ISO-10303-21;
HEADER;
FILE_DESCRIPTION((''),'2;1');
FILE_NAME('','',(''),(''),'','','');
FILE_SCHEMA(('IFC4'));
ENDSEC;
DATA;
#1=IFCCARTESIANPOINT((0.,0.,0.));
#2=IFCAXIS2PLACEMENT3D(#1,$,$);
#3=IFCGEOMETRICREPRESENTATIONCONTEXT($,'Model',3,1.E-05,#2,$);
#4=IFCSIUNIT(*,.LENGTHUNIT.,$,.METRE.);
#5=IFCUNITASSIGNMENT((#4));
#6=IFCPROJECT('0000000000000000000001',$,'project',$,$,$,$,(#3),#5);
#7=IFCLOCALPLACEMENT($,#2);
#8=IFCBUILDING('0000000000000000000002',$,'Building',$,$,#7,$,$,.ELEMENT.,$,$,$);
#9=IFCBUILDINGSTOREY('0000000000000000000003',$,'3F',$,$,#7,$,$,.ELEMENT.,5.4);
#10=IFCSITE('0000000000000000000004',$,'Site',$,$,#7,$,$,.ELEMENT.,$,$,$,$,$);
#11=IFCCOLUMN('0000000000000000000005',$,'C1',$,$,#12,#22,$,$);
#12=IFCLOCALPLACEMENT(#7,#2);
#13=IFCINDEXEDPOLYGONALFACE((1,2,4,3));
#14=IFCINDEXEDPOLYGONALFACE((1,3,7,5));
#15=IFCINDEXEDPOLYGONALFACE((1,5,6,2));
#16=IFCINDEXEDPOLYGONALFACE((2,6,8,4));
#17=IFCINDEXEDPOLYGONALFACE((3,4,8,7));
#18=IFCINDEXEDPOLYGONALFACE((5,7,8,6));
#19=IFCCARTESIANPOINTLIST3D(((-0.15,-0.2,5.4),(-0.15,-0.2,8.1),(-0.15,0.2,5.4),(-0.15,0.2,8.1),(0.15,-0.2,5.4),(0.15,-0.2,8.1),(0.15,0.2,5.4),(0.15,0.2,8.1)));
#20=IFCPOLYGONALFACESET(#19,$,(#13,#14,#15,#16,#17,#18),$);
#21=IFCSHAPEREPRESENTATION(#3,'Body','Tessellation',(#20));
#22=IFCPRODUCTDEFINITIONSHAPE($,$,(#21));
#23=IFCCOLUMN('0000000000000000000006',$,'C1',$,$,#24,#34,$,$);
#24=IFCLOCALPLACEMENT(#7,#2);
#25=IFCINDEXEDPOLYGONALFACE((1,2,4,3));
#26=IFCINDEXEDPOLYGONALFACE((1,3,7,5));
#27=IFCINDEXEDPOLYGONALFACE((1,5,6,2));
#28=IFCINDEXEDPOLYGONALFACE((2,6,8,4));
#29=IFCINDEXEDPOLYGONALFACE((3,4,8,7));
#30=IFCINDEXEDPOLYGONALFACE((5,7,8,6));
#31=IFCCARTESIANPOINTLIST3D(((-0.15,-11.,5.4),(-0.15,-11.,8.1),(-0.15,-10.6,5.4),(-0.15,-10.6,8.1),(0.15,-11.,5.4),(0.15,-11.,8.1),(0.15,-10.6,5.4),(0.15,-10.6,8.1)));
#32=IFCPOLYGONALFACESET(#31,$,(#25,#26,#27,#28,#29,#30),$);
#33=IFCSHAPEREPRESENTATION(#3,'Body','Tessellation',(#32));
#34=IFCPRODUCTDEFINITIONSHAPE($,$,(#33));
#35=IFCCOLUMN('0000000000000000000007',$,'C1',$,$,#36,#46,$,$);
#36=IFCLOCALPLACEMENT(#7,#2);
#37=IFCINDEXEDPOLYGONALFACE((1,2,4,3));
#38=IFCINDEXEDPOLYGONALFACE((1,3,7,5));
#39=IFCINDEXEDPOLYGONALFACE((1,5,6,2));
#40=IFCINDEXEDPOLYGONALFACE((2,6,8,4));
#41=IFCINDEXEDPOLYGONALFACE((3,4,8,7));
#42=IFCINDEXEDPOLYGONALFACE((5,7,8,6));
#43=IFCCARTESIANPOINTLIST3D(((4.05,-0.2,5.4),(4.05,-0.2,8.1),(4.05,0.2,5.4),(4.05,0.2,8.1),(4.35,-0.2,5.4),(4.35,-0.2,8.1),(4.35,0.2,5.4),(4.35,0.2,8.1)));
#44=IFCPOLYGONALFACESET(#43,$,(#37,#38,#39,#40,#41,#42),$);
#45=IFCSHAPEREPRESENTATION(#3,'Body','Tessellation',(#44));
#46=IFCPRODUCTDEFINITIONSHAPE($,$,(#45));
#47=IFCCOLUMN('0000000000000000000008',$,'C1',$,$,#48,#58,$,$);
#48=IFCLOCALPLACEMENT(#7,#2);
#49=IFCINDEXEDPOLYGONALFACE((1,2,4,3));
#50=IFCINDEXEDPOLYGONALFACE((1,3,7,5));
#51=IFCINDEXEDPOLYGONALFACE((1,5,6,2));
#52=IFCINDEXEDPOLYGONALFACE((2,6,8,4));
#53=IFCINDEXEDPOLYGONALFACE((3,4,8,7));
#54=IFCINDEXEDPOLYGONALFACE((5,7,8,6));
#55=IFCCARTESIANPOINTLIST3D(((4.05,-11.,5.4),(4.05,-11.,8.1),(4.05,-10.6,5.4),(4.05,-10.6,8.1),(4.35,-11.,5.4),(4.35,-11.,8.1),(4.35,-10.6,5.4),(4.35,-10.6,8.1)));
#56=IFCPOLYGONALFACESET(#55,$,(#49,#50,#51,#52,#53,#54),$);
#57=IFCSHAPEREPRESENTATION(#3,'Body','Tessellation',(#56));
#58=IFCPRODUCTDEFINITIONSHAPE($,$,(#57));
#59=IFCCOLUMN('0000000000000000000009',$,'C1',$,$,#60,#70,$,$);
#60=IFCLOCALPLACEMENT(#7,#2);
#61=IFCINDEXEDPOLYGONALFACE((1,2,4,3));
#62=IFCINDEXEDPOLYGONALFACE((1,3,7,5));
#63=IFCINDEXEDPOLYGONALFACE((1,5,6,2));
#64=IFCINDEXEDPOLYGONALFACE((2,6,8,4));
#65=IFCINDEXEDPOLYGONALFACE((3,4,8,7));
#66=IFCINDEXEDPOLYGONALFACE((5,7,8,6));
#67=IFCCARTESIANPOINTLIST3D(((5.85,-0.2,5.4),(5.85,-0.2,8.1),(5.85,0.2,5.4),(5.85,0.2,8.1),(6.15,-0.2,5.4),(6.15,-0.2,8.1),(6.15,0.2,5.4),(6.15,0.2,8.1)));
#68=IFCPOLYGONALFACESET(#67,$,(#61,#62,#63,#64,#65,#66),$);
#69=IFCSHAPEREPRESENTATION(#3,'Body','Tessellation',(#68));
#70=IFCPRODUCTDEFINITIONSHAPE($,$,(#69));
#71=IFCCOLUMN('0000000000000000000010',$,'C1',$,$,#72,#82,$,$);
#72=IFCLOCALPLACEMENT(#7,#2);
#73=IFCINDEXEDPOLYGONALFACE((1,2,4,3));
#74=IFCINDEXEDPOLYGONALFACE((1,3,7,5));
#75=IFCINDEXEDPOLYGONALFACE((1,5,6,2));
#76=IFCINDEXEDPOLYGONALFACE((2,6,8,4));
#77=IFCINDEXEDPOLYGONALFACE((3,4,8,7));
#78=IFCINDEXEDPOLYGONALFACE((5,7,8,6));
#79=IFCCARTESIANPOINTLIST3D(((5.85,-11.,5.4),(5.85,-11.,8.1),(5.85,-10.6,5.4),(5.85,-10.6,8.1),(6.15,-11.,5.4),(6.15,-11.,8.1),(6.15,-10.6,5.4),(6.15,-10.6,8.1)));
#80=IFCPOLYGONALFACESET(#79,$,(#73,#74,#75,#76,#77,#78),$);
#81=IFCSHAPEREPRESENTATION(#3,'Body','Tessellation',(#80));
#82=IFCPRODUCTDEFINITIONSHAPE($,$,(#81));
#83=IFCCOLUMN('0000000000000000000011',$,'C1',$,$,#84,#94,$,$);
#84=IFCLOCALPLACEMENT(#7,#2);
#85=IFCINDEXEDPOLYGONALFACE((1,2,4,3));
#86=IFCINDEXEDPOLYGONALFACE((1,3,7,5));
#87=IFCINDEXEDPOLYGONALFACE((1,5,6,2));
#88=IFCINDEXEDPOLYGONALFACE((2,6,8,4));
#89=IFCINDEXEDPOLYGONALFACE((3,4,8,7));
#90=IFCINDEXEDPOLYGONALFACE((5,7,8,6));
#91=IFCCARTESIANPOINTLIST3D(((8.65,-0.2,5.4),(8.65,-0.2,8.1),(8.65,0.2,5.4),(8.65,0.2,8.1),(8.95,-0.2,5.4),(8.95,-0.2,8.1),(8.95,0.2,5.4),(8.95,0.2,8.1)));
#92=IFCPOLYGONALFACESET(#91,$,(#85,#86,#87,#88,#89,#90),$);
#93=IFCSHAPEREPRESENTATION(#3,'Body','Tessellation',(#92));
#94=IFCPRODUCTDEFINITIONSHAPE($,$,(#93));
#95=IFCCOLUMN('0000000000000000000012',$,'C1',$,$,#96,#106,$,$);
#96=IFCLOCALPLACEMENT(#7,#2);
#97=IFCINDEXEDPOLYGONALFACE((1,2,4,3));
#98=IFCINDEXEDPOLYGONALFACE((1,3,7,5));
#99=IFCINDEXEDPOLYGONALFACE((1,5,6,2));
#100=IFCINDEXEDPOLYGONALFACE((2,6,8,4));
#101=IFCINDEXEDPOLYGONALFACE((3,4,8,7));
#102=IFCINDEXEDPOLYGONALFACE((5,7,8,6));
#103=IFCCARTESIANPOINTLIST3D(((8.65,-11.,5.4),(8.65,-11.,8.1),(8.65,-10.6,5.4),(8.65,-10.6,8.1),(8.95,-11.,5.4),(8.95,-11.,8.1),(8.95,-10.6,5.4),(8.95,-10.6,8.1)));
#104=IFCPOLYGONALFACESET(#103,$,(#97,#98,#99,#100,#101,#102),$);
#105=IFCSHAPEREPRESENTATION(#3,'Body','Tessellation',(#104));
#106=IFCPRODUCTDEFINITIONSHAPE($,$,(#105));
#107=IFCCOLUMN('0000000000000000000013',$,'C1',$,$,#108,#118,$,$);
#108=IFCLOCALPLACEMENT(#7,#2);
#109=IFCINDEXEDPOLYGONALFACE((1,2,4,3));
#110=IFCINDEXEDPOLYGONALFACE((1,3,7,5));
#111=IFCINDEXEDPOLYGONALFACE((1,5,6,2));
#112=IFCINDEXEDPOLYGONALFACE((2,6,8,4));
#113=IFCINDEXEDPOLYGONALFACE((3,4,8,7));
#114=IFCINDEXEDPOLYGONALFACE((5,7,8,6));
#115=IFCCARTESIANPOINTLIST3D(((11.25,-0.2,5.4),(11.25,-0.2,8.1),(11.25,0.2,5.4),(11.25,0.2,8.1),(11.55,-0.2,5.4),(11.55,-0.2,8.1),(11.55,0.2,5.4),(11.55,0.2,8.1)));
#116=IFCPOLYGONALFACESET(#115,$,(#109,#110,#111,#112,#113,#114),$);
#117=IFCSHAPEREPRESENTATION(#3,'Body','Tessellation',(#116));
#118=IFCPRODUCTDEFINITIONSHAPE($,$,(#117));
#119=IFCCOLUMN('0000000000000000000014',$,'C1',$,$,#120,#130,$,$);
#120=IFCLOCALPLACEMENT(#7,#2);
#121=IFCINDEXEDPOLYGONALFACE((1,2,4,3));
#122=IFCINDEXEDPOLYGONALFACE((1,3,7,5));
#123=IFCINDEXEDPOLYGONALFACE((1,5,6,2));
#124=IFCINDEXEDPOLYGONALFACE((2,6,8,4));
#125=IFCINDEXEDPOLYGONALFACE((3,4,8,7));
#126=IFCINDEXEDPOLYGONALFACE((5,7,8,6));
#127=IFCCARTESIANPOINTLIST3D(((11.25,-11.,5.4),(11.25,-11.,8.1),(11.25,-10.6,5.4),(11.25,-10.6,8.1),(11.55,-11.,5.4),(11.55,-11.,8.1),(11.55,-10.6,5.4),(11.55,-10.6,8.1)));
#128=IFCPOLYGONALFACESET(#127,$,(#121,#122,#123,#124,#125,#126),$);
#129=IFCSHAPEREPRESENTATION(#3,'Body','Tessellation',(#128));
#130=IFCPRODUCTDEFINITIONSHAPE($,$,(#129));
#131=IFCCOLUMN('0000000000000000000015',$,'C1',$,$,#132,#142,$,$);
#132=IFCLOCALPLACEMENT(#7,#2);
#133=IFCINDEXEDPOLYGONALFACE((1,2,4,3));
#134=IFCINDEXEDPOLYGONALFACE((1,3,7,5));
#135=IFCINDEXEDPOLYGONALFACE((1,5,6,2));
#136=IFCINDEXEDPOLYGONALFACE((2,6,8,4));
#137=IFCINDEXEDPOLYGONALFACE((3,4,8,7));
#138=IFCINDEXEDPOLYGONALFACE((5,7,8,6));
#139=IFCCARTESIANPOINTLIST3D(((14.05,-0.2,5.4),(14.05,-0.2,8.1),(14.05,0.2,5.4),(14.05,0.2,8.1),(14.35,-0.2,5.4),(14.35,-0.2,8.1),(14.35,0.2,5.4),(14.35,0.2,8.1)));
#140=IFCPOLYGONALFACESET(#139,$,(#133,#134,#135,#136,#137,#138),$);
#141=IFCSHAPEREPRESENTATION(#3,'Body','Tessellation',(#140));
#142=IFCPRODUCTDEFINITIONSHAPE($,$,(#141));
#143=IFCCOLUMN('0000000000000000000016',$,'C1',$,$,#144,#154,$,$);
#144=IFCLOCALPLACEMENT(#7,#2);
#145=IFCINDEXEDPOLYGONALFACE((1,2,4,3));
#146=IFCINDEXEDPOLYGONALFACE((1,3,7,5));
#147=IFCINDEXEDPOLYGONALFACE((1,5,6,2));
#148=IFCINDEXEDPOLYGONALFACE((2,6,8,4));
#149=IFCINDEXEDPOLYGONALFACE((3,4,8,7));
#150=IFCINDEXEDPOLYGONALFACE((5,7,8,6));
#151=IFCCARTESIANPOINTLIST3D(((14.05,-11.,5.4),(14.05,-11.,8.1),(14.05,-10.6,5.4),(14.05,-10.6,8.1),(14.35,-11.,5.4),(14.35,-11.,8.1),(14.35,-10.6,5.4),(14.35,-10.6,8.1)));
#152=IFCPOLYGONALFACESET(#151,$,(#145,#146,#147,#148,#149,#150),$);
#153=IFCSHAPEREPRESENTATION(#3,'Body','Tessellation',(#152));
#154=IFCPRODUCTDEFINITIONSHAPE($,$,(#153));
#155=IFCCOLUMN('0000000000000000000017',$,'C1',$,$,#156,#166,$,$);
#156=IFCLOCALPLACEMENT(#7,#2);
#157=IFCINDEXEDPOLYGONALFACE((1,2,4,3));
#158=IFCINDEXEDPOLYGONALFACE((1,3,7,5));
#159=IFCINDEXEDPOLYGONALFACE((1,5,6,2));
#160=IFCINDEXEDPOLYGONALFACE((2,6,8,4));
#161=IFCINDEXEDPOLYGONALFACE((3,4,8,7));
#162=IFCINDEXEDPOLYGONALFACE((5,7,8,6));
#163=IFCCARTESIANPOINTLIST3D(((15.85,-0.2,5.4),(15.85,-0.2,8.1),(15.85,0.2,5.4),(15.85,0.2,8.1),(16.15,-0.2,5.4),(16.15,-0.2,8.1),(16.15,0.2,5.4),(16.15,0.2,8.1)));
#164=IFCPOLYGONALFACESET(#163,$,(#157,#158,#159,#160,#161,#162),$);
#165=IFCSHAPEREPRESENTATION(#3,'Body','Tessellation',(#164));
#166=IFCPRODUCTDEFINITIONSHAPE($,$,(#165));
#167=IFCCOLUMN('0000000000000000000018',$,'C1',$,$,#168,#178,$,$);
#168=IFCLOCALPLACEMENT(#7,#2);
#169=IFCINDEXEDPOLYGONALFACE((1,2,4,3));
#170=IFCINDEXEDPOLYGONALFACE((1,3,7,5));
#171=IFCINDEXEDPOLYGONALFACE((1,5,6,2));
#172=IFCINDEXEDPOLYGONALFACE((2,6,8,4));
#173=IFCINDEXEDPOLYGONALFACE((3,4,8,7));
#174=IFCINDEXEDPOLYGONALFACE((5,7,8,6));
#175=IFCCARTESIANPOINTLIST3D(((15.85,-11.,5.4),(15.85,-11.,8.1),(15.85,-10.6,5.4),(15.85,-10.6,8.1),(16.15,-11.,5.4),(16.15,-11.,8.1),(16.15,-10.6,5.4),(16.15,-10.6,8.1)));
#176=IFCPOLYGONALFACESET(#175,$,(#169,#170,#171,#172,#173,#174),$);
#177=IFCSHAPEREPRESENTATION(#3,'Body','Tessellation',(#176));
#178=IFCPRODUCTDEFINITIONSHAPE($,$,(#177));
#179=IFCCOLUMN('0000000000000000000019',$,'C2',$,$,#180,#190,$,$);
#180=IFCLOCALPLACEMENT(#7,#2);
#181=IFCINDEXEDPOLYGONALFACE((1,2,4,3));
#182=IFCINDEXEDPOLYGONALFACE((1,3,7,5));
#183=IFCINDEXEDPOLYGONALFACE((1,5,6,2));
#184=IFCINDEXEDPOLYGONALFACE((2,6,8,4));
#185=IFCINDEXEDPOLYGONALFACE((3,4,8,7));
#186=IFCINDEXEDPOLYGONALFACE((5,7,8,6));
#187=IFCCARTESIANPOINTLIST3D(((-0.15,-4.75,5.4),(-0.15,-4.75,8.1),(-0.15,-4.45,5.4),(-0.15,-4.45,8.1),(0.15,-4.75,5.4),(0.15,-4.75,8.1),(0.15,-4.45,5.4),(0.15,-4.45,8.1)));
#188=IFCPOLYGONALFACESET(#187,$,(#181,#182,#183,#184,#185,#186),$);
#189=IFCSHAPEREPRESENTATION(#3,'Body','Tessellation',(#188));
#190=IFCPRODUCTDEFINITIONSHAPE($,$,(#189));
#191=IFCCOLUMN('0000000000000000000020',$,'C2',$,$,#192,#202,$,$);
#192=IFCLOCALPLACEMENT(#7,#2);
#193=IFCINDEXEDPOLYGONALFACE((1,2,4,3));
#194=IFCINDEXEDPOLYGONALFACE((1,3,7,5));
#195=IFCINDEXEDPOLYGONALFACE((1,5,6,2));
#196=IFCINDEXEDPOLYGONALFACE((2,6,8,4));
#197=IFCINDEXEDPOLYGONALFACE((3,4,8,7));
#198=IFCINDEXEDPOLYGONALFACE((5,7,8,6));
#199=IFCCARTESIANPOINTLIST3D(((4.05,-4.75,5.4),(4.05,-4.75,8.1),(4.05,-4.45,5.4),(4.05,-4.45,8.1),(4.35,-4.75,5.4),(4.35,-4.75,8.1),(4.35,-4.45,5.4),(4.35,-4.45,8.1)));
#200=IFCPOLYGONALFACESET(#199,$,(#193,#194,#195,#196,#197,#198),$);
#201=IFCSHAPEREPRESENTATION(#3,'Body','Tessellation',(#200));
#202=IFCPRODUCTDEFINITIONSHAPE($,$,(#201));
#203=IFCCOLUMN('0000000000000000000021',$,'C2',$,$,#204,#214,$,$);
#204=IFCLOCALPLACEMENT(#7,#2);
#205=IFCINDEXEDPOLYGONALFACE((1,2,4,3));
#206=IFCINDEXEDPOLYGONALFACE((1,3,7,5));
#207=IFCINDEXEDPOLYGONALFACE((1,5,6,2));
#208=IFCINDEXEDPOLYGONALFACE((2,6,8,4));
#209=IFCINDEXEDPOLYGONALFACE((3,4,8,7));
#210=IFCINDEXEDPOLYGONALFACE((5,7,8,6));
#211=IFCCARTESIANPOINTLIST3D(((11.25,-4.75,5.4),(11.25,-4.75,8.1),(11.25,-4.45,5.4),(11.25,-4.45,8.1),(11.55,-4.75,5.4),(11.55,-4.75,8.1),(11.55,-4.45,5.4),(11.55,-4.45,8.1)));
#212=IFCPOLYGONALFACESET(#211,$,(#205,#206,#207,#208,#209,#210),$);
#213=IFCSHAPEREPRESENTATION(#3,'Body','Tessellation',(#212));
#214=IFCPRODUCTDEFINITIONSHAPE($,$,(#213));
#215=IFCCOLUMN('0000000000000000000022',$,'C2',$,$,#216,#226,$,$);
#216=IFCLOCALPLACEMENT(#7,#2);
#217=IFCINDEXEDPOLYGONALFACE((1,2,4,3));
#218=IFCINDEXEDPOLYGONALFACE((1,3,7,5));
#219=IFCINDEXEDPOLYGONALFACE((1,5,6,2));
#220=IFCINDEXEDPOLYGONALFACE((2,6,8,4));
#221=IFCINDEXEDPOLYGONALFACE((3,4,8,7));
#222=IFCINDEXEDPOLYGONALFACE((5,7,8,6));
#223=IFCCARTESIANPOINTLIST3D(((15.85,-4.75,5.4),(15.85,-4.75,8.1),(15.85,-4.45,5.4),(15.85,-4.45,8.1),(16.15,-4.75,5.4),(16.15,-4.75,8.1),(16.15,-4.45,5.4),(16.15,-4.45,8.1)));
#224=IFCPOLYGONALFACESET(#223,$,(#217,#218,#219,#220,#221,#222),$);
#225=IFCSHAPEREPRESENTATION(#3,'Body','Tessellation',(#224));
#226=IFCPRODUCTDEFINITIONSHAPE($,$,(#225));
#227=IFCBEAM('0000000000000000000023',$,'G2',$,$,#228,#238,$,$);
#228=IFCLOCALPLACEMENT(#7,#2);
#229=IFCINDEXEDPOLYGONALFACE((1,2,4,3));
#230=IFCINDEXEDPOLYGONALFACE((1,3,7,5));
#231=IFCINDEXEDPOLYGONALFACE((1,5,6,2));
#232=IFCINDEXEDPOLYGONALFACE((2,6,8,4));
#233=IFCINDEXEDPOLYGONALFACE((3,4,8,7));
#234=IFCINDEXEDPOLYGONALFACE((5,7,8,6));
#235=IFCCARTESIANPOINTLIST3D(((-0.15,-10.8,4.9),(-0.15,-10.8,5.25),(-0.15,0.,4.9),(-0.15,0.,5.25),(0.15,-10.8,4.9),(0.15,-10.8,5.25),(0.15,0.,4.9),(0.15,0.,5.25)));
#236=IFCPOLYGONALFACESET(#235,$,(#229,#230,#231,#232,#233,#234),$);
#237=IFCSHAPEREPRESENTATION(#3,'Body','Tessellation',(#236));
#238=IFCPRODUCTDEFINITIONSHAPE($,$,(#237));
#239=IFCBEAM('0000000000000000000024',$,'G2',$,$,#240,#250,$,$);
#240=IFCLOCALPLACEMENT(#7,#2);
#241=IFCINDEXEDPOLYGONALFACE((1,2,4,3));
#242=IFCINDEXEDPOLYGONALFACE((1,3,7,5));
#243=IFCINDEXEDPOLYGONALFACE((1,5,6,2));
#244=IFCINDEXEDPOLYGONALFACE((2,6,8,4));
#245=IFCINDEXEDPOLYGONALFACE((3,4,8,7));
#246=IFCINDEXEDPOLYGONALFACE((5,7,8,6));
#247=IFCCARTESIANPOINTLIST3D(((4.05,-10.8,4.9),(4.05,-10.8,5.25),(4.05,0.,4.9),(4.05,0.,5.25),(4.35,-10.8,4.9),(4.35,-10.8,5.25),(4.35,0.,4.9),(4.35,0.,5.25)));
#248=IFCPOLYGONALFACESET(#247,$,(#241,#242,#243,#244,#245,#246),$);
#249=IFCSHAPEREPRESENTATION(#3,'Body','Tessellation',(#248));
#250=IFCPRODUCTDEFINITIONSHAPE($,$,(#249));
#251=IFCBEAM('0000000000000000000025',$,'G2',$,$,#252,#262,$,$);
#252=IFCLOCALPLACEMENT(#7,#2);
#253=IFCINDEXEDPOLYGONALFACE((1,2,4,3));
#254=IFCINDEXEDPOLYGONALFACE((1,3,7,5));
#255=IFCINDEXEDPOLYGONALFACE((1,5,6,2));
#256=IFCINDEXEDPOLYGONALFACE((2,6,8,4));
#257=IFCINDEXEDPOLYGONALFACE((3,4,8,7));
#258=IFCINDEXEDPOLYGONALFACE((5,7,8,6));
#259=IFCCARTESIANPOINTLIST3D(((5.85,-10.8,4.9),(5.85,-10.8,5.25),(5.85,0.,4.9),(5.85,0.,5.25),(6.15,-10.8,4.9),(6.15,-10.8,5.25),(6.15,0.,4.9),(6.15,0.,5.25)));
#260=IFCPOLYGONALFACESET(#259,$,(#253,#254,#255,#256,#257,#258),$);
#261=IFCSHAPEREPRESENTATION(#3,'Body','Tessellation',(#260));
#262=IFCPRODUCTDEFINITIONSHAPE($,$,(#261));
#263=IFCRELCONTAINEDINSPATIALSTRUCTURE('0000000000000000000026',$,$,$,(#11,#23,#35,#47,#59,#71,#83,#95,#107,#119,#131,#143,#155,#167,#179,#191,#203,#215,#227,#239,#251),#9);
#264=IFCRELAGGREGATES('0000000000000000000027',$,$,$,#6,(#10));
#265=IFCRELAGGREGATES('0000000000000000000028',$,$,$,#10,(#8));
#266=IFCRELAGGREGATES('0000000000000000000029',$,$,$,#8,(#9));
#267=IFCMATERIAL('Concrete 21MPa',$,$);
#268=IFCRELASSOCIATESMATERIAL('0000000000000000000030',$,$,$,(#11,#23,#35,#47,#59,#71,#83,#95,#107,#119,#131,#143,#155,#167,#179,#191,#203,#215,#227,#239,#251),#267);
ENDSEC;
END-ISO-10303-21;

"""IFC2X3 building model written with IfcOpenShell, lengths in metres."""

from ifc_helpers import new_model, si_unit, frame, origin, origin_2d, place, context, project, spatial, rectangle, extrude, material, element, save


model = new_model("IFC2X3")

# Units and contexts
model_context = context("Model", 3, precision=1e-05, world=origin())
ifc_project = project(units=[si_unit("LENGTHUNIT", "METRE")], contexts=[model_context])

# Site, building, storey
placement = place(None, origin())
site = spatial("IfcSite", under=ifc_project, at=placement, Name="Site", CompositionType="ELEMENT")
building = spatial("IfcBuilding", under=site, at=placement, Name="Building", CompositionType="ELEMENT")
storey = spatial("IfcBuildingStorey", under=building, at=placement, Name="3F", CompositionType="ELEMENT", Elevation=5.4)

# Columns
ifc_material = material(Name="Concrete 21MPa")
for number, where, name in (
    (1, (0.0, 0.0, 5.4), "C1"),
    (2, (0.0, -10.8, 5.4), "C1"),
    (3, (4.2, 0.0, 5.4), "C1"),
    (4, (4.2, -10.8, 5.4), "C1"),
    (5, (6.0, 0.0, 5.4), "C1"),
    (6, (6.0, -10.8, 5.4), "C1"),
    (7, (8.8, 0.0, 5.4), "C1"),
    (8, (8.8, -10.8, 5.4), "C1"),
    (9, (11.4, 0.0, 5.4), "C1"),
    (10, (11.4, -10.8, 5.4), "C1"),
    (11, (14.2, 0.0, 5.4), "C1"),
    (12, (14.2, -10.8, 5.4), "C1"),
    (13, (16.0, 0.0, 5.4), "C1"),
    (14, (16.0, -10.8, 5.4), "C1"),
):
    element("IfcColumn", number, at=place(None, frame(where)), inside=storey, material=ifc_material, Name=name, context=model_context, shape_type="SweptSolid", body=[
        extrude(rectangle(XDim=0.3, YDim=0.4, at=origin_2d()), origin(), (0.0, 0.0, 1.0), 2.7),
    ])
for number, where, name in (
    (15, (0.0, -4.6, 5.4), "C2"),
    (16, (4.2, -4.6, 5.4), "C2"),
    (17, (11.4, -4.6, 5.4), "C2"),
    (18, (16.0, -4.6, 5.4), "C2"),
):
    element("IfcColumn", number, at=place(None, frame(where)), inside=storey, material=ifc_material, Name=name, context=model_context, shape_type="SweptSolid", body=[
        extrude(rectangle(XDim=0.3, YDim=0.3, at=origin_2d()), origin(), (0.0, 0.0, 1.0), 2.7),
    ])

# Beams
for number, where, name in (
    (19, (0.0, -5.4, 4.9), "G2"),
    (20, (4.2, -5.4, 4.9), "G2"),
    (21, (6.0, -5.4, 4.9), "G2"),
):
    element("IfcBeam", number, at=place(None, frame(where)), inside=storey, material=ifc_material, Name=name, context=model_context, shape_type="SweptSolid", body=[
        extrude(rectangle(XDim=0.3, YDim=10.8, at=origin_2d()), origin(), (0.0, 0.0, 1.0), 0.35),
    ])

save(model, "model.ifc")
